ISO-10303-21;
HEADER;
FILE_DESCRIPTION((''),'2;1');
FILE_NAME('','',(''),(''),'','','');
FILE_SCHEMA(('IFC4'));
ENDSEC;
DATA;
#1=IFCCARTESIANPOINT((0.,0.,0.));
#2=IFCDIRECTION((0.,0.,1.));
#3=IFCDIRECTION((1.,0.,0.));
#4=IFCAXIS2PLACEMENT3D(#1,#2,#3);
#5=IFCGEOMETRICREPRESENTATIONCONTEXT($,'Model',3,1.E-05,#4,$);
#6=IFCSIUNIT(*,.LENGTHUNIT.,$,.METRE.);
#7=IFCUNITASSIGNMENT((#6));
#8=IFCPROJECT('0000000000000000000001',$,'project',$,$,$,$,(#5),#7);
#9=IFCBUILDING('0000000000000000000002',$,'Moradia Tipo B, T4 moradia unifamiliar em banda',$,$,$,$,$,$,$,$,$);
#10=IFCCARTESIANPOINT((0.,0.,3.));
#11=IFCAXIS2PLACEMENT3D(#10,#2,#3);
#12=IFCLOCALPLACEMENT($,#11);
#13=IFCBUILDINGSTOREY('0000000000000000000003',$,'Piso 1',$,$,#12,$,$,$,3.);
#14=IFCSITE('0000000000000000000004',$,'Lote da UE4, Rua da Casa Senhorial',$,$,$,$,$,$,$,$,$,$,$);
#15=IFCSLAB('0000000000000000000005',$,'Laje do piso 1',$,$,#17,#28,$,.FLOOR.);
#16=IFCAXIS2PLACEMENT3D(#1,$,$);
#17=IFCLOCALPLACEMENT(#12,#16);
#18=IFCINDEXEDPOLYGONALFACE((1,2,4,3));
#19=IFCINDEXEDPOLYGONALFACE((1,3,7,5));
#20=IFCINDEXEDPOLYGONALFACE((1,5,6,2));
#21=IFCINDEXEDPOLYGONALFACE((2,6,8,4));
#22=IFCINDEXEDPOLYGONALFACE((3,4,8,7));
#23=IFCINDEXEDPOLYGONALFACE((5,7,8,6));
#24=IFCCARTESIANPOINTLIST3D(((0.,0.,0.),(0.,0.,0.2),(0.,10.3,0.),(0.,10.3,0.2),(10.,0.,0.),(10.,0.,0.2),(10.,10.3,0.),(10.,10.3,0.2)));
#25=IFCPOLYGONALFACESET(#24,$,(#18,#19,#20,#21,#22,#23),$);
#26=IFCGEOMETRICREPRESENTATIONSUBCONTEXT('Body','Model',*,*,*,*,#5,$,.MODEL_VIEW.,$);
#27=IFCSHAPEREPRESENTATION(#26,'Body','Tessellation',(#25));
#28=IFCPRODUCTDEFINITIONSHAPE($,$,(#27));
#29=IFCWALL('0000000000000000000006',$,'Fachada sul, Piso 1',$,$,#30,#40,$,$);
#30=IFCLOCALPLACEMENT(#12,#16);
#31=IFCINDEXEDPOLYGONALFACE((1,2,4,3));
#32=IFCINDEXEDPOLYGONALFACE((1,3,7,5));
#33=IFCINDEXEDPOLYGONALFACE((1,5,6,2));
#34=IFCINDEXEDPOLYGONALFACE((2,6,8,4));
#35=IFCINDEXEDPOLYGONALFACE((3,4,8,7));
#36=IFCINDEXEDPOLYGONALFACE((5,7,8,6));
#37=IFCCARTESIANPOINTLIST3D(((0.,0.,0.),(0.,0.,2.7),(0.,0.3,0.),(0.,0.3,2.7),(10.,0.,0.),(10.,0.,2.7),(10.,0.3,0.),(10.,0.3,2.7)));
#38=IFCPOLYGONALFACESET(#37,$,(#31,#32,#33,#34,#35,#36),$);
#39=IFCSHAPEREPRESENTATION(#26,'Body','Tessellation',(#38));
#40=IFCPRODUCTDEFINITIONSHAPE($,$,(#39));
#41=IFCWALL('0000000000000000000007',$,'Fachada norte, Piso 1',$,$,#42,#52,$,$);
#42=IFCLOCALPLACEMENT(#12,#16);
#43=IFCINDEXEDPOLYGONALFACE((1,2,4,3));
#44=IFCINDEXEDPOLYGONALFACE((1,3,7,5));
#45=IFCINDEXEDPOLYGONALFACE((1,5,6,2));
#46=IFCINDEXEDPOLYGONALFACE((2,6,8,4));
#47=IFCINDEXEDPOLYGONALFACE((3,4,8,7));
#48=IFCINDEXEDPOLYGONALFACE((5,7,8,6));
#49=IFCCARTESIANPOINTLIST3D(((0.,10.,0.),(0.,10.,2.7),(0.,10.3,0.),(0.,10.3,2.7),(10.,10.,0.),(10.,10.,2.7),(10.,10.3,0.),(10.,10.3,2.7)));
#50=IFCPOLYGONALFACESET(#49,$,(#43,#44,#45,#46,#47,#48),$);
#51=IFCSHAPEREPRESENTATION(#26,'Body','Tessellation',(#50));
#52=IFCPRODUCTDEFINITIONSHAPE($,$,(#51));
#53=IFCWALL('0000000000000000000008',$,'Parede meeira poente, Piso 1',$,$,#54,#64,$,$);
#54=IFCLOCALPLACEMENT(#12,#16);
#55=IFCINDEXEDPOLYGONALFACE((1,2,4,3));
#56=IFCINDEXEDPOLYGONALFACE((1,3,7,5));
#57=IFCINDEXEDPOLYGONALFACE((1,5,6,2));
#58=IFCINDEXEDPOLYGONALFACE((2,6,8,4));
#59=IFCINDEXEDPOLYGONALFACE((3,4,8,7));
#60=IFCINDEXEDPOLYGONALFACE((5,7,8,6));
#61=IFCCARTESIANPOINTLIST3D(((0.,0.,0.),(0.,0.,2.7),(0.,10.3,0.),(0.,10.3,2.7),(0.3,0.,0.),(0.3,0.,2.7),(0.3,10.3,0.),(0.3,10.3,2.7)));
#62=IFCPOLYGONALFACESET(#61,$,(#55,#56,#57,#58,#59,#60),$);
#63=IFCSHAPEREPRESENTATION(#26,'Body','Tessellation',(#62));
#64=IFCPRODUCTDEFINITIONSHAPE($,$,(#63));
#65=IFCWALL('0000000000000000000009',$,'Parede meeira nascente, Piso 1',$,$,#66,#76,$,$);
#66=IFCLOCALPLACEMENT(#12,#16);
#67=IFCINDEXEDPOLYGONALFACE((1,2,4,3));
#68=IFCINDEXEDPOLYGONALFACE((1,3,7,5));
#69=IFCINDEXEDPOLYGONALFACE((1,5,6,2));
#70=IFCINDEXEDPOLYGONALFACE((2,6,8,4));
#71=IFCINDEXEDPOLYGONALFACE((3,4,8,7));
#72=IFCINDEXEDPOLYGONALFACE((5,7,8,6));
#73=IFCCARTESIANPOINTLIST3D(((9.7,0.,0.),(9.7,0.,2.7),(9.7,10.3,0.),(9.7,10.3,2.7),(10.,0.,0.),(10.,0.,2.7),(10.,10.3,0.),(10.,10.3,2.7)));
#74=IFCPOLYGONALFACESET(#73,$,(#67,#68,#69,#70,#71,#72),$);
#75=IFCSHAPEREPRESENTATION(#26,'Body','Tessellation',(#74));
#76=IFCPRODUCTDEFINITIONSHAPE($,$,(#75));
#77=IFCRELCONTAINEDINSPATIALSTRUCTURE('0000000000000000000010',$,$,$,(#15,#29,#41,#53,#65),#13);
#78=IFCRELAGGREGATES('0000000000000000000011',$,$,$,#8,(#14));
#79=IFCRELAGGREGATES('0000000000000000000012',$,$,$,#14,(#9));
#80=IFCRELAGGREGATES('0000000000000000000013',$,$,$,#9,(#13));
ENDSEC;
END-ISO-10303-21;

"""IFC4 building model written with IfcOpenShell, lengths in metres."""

from ifc_helpers import new_model, si_unit, frame, origin_with_axes, place, context, subcontext, project, spatial, indexed_curve, outline, extrude, element, save


model = new_model("IFC4")

# Units and contexts
model_context = context("Model", 3, precision=1e-05, world=origin_with_axes())
body_context = subcontext(model_context, "Body", "Model", "MODEL_VIEW")
ifc_project = project(units=[si_unit("LENGTHUNIT", "METRE")], contexts=[model_context])

# Site, building, storey
site = spatial("IfcSite", under=ifc_project, Name="Lote da UE4, Rua da Casa Senhorial")
building = spatial("IfcBuilding", under=site, Name="Moradia Tipo B, T4 moradia unifamiliar em banda")
storey_placement = place(None, frame((0.0, 0.0, 3.0), z_axis=(0.0, 0.0, 1.0), x_axis=(1.0, 0.0, 0.0)))
storey = spatial("IfcBuildingStorey", under=building, at=storey_placement, Name="Piso 1", Elevation=3.0)

# Slab
slab_placement = place(storey_placement, origin_with_axes())
element("IfcSlab", 1, at=slab_placement, inside=storey, Name="Laje do piso 1", PredefinedType="FLOOR", context=body_context, shape_type="SweptSolid", body=[
    extrude(outline(indexed_curve([(0.0, 0.0), (10.0, 0.0), (10.0, 10.3), (0.0, 10.3), (0.0, 0.0)])), None, (0.0, 0.0, 1.0), 0.2),
])

# Walls
for number, where, z_axis, x_axis, name in (
    (2, (0.0, 0.0, 0.0), (0.0, 0.0, 1.0), (1.0, 0.0, 0.0), "Fachada sul, Piso 1"),
    (3, (0.0, 10.0, 0.0), (0.0, 0.0, 1.0), (1.0, 0.0, 0.0), "Fachada norte, Piso 1"),
):
    element("IfcWall", number, at=place(storey_placement, frame(where, z_axis=z_axis, x_axis=x_axis)), inside=storey, Name=name, context=body_context, shape_type="SweptSolid", body=[
        extrude(outline(indexed_curve([(0.0, 0.0), (0.0, 0.3), (10.0, 0.3), (10.0, 0.0), (0.0, 0.0)], self_intersect=False)), origin_with_axes(), (0.0, 0.0, 1.0), 2.7),
    ])
for number, where, z_axis, x_axis, name in (
    (4, (0.3, 0.0, 0.0), (0.0, 0.0, 1.0), (0.0, 1.0, 0.0), "Parede meeira poente, Piso 1"),
    (5, (10.0, 0.0, 0.0), (0.0, 0.0, 1.0), (0.0, 1.0, 0.0), "Parede meeira nascente, Piso 1"),
):
    element("IfcWall", number, at=place(storey_placement, frame(where, z_axis=z_axis, x_axis=x_axis)), inside=storey, Name=name, context=body_context, shape_type="SweptSolid", body=[
        extrude(outline(indexed_curve([(0.0, 0.0), (0.0, 0.3), (10.3, 0.3), (10.3, 0.0), (0.0, 0.0)], self_intersect=False)), origin_with_axes(), (0.0, 0.0, 1.0), 2.7),
    ])

save(model, "model.ifc")
